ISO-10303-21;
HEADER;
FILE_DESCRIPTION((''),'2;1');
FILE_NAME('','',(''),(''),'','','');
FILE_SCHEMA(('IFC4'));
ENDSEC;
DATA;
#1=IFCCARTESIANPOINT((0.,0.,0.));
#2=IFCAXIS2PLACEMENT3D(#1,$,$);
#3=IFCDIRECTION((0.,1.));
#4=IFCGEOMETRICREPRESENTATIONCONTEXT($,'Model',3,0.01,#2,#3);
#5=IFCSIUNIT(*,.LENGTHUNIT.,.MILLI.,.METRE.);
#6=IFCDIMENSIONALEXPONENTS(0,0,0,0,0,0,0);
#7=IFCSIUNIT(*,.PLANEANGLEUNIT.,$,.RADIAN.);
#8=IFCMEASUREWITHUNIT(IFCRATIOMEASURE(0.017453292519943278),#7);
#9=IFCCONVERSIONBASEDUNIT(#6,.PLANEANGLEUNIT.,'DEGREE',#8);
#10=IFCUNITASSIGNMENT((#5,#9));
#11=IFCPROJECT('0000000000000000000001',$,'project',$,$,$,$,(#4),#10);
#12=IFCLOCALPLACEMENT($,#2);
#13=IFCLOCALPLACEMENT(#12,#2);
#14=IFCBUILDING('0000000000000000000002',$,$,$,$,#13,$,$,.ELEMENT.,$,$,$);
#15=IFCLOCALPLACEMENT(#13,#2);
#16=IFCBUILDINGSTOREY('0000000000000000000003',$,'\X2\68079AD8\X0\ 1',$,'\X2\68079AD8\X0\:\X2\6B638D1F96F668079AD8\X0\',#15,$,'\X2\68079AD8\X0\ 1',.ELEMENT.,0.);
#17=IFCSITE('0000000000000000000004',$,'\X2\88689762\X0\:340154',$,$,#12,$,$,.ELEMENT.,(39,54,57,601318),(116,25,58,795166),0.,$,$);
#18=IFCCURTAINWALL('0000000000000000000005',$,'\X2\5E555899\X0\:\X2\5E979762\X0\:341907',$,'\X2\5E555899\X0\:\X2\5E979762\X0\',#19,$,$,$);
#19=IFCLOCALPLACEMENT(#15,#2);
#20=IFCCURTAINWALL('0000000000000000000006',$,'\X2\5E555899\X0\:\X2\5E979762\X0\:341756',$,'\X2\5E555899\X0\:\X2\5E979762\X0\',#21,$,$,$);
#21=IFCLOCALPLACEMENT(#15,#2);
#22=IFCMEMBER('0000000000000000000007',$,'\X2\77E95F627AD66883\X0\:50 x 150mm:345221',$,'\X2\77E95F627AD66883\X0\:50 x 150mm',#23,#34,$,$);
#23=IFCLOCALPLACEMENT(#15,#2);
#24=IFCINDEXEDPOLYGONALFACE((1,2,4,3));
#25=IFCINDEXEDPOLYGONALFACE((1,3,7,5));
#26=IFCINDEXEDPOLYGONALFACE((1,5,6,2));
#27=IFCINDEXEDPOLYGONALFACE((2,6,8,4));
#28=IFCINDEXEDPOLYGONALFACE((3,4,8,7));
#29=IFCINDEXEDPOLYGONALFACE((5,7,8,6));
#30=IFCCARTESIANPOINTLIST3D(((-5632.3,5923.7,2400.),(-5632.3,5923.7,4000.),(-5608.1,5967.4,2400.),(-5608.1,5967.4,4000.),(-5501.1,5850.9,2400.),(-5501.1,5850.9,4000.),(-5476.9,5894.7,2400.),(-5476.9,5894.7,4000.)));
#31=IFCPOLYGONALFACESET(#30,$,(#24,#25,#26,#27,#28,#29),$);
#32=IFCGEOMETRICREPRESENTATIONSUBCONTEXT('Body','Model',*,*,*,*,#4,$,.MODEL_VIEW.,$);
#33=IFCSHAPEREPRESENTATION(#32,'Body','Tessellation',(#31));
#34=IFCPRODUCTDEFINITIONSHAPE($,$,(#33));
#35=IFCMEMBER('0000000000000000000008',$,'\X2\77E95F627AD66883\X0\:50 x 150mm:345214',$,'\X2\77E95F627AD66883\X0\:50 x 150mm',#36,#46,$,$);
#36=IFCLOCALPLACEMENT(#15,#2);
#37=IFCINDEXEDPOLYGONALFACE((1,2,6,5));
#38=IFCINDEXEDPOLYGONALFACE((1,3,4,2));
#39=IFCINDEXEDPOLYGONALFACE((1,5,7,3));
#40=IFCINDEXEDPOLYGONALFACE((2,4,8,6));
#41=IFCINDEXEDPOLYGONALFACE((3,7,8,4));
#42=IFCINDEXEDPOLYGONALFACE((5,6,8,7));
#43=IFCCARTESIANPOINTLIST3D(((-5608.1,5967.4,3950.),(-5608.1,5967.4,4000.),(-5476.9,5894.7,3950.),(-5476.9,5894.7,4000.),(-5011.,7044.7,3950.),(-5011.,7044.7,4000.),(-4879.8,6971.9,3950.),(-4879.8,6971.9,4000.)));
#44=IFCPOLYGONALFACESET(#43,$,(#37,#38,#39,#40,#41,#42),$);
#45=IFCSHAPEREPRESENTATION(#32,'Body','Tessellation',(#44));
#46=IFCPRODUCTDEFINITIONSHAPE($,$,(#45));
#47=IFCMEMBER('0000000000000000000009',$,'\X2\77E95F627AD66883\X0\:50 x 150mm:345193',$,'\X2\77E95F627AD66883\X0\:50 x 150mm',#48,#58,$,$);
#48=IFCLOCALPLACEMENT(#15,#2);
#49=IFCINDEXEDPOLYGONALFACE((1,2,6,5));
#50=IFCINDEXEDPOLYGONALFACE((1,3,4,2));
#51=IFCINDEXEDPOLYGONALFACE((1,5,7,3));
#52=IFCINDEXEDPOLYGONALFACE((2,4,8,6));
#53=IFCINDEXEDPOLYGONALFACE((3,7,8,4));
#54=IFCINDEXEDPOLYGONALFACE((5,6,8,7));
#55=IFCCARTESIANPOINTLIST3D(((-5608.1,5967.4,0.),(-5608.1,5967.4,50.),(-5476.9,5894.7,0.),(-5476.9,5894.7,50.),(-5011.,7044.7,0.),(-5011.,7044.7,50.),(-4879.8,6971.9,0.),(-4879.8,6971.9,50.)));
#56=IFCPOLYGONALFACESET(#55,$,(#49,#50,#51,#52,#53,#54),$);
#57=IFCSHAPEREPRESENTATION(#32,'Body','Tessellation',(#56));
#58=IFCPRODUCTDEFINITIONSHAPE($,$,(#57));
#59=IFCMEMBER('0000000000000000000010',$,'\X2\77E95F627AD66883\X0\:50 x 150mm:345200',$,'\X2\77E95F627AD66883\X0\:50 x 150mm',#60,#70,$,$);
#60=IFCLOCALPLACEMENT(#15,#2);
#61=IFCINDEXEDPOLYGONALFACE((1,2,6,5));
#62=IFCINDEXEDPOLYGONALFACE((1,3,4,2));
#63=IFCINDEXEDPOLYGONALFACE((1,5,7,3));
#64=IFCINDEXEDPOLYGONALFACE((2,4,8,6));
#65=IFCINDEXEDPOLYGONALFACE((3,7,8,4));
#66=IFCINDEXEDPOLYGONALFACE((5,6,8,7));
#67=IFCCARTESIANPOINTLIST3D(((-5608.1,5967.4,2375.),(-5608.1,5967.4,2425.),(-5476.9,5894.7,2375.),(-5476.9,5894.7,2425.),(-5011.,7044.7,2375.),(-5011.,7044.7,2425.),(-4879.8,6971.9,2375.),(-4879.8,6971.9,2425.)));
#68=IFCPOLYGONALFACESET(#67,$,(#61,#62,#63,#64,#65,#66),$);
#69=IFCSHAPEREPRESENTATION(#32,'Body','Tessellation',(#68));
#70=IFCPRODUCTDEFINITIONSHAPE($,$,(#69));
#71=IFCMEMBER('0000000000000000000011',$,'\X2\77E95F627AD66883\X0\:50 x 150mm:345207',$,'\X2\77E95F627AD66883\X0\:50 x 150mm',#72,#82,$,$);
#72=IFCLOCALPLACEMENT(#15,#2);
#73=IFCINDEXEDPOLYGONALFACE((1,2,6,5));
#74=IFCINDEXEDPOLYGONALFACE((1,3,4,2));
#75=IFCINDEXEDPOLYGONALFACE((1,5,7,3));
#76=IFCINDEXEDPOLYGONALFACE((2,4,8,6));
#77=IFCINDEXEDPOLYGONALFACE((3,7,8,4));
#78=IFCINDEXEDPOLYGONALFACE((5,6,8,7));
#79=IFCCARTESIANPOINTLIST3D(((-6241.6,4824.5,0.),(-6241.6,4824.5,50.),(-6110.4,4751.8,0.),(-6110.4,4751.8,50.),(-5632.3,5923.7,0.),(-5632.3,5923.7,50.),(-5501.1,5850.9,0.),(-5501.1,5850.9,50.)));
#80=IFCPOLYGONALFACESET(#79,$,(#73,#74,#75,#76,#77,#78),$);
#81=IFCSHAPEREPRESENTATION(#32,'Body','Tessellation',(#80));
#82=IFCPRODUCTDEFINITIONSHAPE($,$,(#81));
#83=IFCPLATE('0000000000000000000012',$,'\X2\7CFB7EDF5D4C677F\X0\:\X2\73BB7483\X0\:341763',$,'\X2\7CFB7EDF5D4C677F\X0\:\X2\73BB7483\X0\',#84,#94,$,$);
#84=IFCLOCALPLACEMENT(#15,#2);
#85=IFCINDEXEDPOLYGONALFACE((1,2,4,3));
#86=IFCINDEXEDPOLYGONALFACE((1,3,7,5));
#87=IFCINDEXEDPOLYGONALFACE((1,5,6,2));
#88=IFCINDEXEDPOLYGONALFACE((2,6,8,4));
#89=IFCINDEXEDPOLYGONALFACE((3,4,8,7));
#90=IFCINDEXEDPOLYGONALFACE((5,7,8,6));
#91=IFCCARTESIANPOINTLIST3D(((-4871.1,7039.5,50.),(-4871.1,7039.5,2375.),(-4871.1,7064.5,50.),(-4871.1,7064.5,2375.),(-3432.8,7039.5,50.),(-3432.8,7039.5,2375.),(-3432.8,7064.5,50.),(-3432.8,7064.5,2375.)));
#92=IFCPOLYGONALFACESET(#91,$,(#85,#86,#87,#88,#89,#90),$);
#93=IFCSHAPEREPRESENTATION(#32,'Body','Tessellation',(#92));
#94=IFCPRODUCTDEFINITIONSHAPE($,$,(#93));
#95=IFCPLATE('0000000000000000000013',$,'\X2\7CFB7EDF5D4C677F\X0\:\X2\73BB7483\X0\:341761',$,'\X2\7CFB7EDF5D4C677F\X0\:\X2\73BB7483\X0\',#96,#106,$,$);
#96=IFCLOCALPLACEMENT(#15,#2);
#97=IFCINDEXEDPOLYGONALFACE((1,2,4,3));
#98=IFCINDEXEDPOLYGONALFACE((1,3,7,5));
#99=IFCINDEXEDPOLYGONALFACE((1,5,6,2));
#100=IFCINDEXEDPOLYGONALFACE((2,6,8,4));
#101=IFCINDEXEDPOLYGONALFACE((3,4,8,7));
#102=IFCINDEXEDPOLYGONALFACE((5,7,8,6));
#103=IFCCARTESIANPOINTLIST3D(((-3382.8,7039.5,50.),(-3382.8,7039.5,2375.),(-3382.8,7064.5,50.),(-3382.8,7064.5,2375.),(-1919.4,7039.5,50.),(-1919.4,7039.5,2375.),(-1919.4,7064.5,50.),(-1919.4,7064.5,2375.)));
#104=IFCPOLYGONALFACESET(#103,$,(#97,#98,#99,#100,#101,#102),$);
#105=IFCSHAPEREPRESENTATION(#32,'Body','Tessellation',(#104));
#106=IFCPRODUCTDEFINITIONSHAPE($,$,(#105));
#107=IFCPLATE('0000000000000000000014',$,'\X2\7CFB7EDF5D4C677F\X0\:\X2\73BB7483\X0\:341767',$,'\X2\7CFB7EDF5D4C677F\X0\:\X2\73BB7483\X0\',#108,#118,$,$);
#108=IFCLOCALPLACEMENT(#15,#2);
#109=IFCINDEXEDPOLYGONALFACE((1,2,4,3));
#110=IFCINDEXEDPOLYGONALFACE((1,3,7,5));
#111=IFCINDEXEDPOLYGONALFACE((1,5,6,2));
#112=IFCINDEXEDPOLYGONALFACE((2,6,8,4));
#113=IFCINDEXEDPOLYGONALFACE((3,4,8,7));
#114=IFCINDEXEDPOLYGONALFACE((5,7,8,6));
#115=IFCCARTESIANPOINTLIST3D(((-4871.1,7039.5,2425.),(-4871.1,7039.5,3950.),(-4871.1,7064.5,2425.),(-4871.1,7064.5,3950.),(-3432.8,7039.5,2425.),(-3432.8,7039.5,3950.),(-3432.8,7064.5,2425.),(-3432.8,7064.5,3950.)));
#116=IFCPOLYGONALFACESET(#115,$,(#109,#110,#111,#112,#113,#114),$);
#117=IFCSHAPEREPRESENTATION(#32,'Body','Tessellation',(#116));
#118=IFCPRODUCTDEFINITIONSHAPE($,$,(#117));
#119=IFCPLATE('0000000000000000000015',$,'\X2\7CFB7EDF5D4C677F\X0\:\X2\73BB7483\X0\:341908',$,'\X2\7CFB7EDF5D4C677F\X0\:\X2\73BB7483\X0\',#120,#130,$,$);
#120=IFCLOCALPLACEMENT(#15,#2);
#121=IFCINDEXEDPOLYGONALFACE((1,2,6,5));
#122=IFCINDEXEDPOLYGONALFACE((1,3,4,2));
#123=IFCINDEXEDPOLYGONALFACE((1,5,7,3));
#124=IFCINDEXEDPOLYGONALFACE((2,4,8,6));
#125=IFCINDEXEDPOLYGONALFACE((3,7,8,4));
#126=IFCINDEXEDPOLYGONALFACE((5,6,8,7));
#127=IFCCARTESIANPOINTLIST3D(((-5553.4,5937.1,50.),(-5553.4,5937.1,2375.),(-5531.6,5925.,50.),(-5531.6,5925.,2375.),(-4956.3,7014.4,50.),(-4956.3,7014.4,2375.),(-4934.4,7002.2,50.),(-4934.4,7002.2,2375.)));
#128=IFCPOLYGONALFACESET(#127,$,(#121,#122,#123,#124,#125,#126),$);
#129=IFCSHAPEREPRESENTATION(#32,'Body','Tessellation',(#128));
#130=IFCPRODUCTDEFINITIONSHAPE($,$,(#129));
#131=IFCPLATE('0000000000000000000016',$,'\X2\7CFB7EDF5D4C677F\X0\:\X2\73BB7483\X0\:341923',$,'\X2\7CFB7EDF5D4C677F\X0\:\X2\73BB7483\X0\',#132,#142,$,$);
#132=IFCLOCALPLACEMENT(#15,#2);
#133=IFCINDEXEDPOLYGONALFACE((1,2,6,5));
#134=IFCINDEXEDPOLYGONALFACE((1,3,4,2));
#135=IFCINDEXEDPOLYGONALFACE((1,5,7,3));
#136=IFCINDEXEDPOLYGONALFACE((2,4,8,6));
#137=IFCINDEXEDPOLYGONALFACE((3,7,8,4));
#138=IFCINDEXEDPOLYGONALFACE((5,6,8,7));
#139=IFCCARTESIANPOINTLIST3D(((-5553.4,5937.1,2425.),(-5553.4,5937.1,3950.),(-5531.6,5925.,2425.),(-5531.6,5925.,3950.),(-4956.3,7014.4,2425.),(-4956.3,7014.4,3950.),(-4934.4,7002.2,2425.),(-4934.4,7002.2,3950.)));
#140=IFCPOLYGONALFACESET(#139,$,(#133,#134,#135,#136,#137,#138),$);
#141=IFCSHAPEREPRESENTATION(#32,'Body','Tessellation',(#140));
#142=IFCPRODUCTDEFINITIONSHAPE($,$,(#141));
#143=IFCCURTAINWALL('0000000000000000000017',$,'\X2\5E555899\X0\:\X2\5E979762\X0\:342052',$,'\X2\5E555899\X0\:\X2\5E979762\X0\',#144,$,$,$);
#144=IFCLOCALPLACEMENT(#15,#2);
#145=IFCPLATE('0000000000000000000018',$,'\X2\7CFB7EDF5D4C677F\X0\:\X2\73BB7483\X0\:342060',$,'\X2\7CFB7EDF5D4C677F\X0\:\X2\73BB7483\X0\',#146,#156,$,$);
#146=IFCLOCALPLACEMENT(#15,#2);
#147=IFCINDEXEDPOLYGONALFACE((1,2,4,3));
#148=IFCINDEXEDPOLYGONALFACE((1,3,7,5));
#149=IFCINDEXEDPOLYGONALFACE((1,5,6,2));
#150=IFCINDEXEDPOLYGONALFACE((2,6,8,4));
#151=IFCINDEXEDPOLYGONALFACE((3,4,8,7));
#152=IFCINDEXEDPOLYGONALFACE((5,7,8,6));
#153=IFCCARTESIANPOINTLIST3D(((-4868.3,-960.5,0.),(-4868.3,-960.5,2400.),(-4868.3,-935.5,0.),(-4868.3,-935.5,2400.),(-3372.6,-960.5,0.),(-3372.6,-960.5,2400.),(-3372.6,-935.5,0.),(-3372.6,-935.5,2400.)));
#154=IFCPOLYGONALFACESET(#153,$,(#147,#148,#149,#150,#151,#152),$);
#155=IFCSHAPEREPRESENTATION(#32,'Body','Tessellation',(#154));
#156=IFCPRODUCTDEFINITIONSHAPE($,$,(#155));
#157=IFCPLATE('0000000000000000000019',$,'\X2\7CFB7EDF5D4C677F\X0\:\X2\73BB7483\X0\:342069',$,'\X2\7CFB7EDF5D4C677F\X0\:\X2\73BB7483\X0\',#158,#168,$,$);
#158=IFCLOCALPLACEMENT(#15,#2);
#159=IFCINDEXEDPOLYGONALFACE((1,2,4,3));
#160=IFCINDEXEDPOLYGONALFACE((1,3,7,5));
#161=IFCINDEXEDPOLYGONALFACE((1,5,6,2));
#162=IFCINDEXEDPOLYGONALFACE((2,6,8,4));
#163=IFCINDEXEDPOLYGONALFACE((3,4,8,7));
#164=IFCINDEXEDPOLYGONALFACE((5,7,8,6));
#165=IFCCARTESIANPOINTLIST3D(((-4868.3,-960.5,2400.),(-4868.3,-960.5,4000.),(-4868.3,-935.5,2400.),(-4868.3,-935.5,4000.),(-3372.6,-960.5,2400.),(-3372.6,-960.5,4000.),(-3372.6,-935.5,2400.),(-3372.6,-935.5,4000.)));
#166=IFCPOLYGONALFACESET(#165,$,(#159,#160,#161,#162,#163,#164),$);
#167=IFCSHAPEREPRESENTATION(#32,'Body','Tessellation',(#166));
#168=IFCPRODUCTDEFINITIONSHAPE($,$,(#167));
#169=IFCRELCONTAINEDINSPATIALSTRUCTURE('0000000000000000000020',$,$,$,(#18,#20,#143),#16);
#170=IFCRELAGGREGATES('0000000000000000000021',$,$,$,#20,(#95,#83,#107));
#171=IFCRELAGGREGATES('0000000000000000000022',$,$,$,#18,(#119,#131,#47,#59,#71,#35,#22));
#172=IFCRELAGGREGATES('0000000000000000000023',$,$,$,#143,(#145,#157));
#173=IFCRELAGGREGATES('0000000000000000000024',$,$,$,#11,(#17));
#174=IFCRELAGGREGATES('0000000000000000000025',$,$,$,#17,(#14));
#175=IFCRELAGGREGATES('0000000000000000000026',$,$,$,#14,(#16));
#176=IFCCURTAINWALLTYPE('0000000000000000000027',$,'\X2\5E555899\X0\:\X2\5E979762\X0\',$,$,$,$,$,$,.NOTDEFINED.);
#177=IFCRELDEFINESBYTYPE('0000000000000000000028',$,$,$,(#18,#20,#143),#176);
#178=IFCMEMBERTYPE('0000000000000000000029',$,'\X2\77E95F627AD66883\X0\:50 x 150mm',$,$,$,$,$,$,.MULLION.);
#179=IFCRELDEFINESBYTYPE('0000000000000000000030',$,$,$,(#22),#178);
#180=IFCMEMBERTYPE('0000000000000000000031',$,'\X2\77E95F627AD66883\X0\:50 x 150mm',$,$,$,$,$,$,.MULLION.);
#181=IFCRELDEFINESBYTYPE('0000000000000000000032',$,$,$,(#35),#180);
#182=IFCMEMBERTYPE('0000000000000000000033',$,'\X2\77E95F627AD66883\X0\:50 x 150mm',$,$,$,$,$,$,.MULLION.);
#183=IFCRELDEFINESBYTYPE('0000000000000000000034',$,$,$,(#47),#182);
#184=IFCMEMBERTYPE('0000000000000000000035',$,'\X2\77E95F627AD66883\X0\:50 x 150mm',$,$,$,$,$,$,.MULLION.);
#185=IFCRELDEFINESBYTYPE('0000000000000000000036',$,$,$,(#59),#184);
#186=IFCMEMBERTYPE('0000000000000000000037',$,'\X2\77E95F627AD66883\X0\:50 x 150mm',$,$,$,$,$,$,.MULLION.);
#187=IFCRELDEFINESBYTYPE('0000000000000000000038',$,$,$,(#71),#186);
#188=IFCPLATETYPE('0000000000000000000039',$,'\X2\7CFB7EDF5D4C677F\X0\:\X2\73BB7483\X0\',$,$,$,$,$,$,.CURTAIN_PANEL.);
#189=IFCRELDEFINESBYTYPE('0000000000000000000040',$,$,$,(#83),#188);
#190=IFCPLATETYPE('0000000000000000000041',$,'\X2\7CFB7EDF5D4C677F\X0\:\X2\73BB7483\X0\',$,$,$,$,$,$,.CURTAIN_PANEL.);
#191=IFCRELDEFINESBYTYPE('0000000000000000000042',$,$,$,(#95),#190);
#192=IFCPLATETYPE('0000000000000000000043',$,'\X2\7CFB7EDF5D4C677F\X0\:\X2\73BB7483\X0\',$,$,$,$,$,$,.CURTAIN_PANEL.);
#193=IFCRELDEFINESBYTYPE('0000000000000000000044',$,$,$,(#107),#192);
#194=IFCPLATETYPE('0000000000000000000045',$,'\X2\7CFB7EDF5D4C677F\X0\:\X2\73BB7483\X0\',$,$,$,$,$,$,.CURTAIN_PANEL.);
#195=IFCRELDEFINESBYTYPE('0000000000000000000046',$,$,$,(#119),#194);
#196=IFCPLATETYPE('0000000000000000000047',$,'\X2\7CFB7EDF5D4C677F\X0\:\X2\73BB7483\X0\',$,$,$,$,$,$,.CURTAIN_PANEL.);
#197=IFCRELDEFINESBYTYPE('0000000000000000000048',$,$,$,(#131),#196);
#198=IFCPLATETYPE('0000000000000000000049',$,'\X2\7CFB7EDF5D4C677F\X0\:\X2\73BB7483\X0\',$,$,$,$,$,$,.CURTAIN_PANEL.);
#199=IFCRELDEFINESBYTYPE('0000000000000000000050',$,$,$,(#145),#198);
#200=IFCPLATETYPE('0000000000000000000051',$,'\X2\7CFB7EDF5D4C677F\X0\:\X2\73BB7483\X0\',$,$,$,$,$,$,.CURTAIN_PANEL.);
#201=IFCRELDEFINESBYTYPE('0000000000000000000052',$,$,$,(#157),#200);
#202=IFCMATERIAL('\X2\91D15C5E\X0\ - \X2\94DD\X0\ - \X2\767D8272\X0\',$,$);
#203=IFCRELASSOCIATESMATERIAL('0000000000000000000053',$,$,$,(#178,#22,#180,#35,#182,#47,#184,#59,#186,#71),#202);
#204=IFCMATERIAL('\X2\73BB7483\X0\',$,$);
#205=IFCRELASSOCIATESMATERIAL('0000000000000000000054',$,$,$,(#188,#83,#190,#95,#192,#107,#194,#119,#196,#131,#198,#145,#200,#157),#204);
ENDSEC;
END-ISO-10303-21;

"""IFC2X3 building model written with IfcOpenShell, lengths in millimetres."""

from ifc_helpers import new_model, entity, si_unit, converted_unit, direction, frame, frame_2d, origin, origin_2d_with_axis, place, context, subcontext, project, spatial, rectangle, extrude, source, transform, mapped, material, type_object, type_shapes, element, aggregate, save


model = new_model("IFC2X3")

# Units and contexts
model_context = context("Model", 3, precision=0.01, world=origin(), true_north=direction((0.0, 1.0)))
body_context = subcontext(model_context, "Body", "Model", "MODEL_VIEW")
ifc_project = project(units=[si_unit("LENGTHUNIT", "METRE", prefix="MILLI"), converted_unit("PLANEANGLEUNIT", "DEGREE", entity("IfcRatioMeasure", 0.017453292519943278), si_unit("PLANEANGLEUNIT", "RADIAN"), dimensions=[0, 0, 0, 0, 0, 0, 0])], contexts=[model_context])

# Site, building, storey
site_placement = place(None, origin())
site = spatial("IfcSite", under=ifc_project, at=site_placement, Name="表面:340154", CompositionType="ELEMENT", RefLatitude=(39, 54, 57, 601318), RefLongitude=(116, 25, 58, 795166), RefElevation=0.0)
building_placement = place(site_placement, origin())
building = spatial("IfcBuilding", under=site, at=building_placement, CompositionType="ELEMENT")
storey_placement = place(building_placement, origin())
storey = spatial("IfcBuildingStorey", under=building, at=storey_placement, Name="标高 1", ObjectType="标高:正负零标高", LongName="标高 1", CompositionType="ELEMENT", Elevation=0.0)

# Curtain wall
curtain_wall_type = type_object("IfcCurtainWallType", Name="幕墙:店面", PredefinedType="NOTDEFINED")
curtain_wall_1_placement = place(storey_placement, origin())
curtain_wall_1 = element("IfcCurtainWall", 1, at=curtain_wall_1_placement, inside=storey, type_object=curtain_wall_type, Name="幕墙:店面:341907", ObjectType="幕墙:店面")
ifc_material_1 = material(Name="金属 - 铝 - 白色")

# Curtain wall
curtain_wall_2_placement = place(storey_placement, origin())
curtain_wall_2 = element("IfcCurtainWall", 2, at=curtain_wall_2_placement, inside=storey, type_object=curtain_wall_type, Name="幕墙:店面:341756", ObjectType="幕墙:店面")

# Members
member_type_1 = type_object("IfcMemberType", Name="矩形竖梃:50 x 150mm", PredefinedType="MULLION", material=ifc_material_1)
shared_shape_1 = source(origin(), body_context, "Body", "SweptSolid", [
    extrude(rectangle(XDim=150.0, YDim=50.0, at=origin_2d_with_axis()), frame((0.0, 0.0, -1600.0), z_axis=(0.0, 0.0, 1.0), x_axis=(0.0, -1.0, 0.0)), (0.0, 0.0, 1.0), 1600.0),
])
type_shapes(member_type_1, [shared_shape_1])
member_1_placement = place(curtain_wall_1_placement, frame((-5554.6, 5909.2, 2400.0), z_axis=(0.0, 0.0, -1.0), x_axis=(-0.48481, -0.87462, 0.0)))
member_1 = element("IfcMember", 3, at=member_1_placement, type_object=member_type_1, material=ifc_material_1, Name="矩形竖梃:50 x 150mm:345221", ObjectType="矩形竖梃:50 x 150mm", context=body_context, shape_type="MappedRepresentation", body=[
    mapped(shared_shape_1, transform((0.0, 0.0, 0.0), scale=1.0)),
])
member_type_2 = type_object("IfcMemberType", Name="矩形竖梃:50 x 150mm", PredefinedType="MULLION", material=ifc_material_1)
shared_shape_2 = source(origin(), body_context, "Body", "SweptSolid", [
    extrude(rectangle(XDim=150.0, YDim=50.0, at=origin_2d_with_axis()), frame((-25.0, 0.0, -1231.7), z_axis=(0.0, 0.0, 1.0), x_axis=(0.0, -1.0, 0.0)), (0.0, 0.0, 1.0), 1231.7),
])
type_shapes(member_type_2, [shared_shape_2])
member_2_placement = place(curtain_wall_1_placement, frame((-5542.5, 5931.0, 4000.0), z_axis=(-0.48481, -0.87462, 0.0), x_axis=(0.0, 0.0, 1.0)))
member_2 = element("IfcMember", 4, at=member_2_placement, type_object=member_type_2, material=ifc_material_1, Name="矩形竖梃:50 x 150mm:345214", ObjectType="矩形竖梃:50 x 150mm", context=body_context, shape_type="MappedRepresentation", body=[
    mapped(shared_shape_2, transform((0.0, 0.0, 0.0), scale=1.0)),
])
member_type_3 = type_object("IfcMemberType", Name="矩形竖梃:50 x 150mm", PredefinedType="MULLION", material=ifc_material_1)
shared_shape_3 = source(origin(), body_context, "Body", "SweptSolid", [
    extrude(rectangle(XDim=150.0, YDim=50.0, at=origin_2d_with_axis()), frame((-25.0, 0.0, -1231.7), z_axis=(0.0, 0.0, 1.0), x_axis=(0.0, -1.0, 0.0)), (0.0, 0.0, 1.0), 1231.7),
])
type_shapes(member_type_3, [shared_shape_3])
member_3_placement = place(curtain_wall_1_placement, frame((-4945.4, 7008.3, 0.0), z_axis=(0.48481, 0.87462, 0.0), x_axis=(0.0, 0.0, -1.0)))
member_3 = element("IfcMember", 5, at=member_3_placement, type_object=member_type_3, material=ifc_material_1, Name="矩形竖梃:50 x 150mm:345193", ObjectType="矩形竖梃:50 x 150mm", context=body_context, shape_type="MappedRepresentation", body=[
    mapped(shared_shape_3, transform((0.0, 0.0, 0.0), scale=1.0)),
])
member_type_4 = type_object("IfcMemberType", Name="矩形竖梃:50 x 150mm", PredefinedType="MULLION", material=ifc_material_1)
shared_shape_4 = source(origin(), body_context, "Body", "SweptSolid", [
    extrude(rectangle(XDim=150.0, YDim=50.0, at=origin_2d_with_axis()), frame((0.0, 0.0, -1231.7), z_axis=(0.0, 0.0, 1.0), x_axis=(0.0, -1.0, 0.0)), (0.0, 0.0, 1.0), 1231.7),
])
type_shapes(member_type_4, [shared_shape_4])
member_4_placement = place(curtain_wall_1_placement, frame((-5542.5, 5931.0, 2400.0), z_axis=(-0.48481, -0.87462, 0.0), x_axis=(0.0, 0.0, 1.0)))
member_4 = element("IfcMember", 6, at=member_4_placement, type_object=member_type_4, material=ifc_material_1, Name="矩形竖梃:50 x 150mm:345200", ObjectType="矩形竖梃:50 x 150mm", context=body_context, shape_type="MappedRepresentation", body=[
    mapped(shared_shape_4, transform((0.0, 0.0, 0.0), scale=1.0)),
])
member_type_5 = type_object("IfcMemberType", Name="矩形竖梃:50 x 150mm", PredefinedType="MULLION", material=ifc_material_1)
shared_shape_5 = source(origin(), body_context, "Body", "SweptSolid", [
    extrude(rectangle(XDim=150.0, YDim=50.0, at=origin_2d_with_axis()), frame((-25.0, 0.0, -1256.7), z_axis=(0.0, 0.0, 1.0), x_axis=(0.0, -1.0, 0.0)), (0.0, 0.0, 1.0), 1256.7),
])
type_shapes(member_type_5, [shared_shape_5])
member_5_placement = place(curtain_wall_1_placement, frame((-5566.7, 5887.3, 0.0), z_axis=(0.48481, 0.87462, 0.0), x_axis=(0.0, 0.0, -1.0)))
member_5 = element("IfcMember", 7, at=member_5_placement, type_object=member_type_5, material=ifc_material_1, Name="矩形竖梃:50 x 150mm:345207", ObjectType="矩形竖梃:50 x 150mm", context=body_context, shape_type="MappedRepresentation", body=[
    mapped(shared_shape_5, transform((0.0, 0.0, 0.0), scale=1.0)),
])

# Plates
ifc_material_2 = material(Name="玻璃")
plate_type_1 = type_object("IfcPlateType", Name="系统嵌板:玻璃", PredefinedType="CURTAIN_PANEL", material=ifc_material_2)
shared_shape_6 = source(origin(), body_context, "Body", "SweptSolid", [
    extrude(rectangle(XDim=25.0, YDim=1438.3, at=origin_2d_with_axis()), frame((0.0, 0.0, 0.0), z_axis=(0.0, 0.0, 1.0), x_axis=(0.0, 1.0, 0.0)), (0.0, 0.0, 1.0), 2325.0),
])
type_shapes(plate_type_1, [shared_shape_6])
plate_1_placement = place(curtain_wall_2_placement, frame((-4151.9, 7052.0, 50.0), z_axis=(0.0, 0.0, 1.0), x_axis=(-1.0, 0.0, 0.0)))
plate_1 = element("IfcPlate", 8, at=plate_1_placement, type_object=plate_type_1, material=ifc_material_2, Name="系统嵌板:玻璃:341763", ObjectType="系统嵌板:玻璃", context=body_context, shape_type="MappedRepresentation", body=[
    mapped(shared_shape_6, transform((0.0, 0.0, 0.0), scale=1.0)),
])
plate_type_2 = type_object("IfcPlateType", Name="系统嵌板:玻璃", PredefinedType="CURTAIN_PANEL", material=ifc_material_2)
shared_shape_7 = source(origin(), body_context, "Body", "SweptSolid", [
    extrude(rectangle(XDim=25.0, YDim=1463.3, at=origin_2d_with_axis()), frame((0.0, 0.0, 0.0), z_axis=(0.0, 0.0, 1.0), x_axis=(0.0, 1.0, 0.0)), (0.0, 0.0, 1.0), 2325.0),
])
type_shapes(plate_type_2, [shared_shape_7])
plate_2_placement = place(curtain_wall_2_placement, frame((-2651.1, 7052.0, 50.0), z_axis=(0.0, 0.0, 1.0), x_axis=(-1.0, 0.0, 0.0)))
plate_2 = element("IfcPlate", 9, at=plate_2_placement, type_object=plate_type_2, material=ifc_material_2, Name="系统嵌板:玻璃:341761", ObjectType="系统嵌板:玻璃", context=body_context, shape_type="MappedRepresentation", body=[
    mapped(shared_shape_7, transform((0.0, 0.0, 0.0), scale=1.0)),
])
plate_type_3 = type_object("IfcPlateType", Name="系统嵌板:玻璃", PredefinedType="CURTAIN_PANEL", material=ifc_material_2)
shared_shape_8 = source(origin(), body_context, "Body", "SweptSolid", [
    extrude(rectangle(XDim=25.0, YDim=1438.3, at=origin_2d_with_axis()), frame((0.0, 0.0, 0.0), z_axis=(0.0, 0.0, 1.0), x_axis=(0.0, 1.0, 0.0)), (0.0, 0.0, 1.0), 1525.0),
])
type_shapes(plate_type_3, [shared_shape_8])
plate_3_placement = place(curtain_wall_2_placement, frame((-4151.9, 7052.0, 2425.0), z_axis=(0.0, 0.0, 1.0), x_axis=(-1.0, 0.0, 0.0)))
plate_3 = element("IfcPlate", 10, at=plate_3_placement, type_object=plate_type_3, material=ifc_material_2, Name="系统嵌板:玻璃:341767", ObjectType="系统嵌板:玻璃", context=body_context, shape_type="MappedRepresentation", body=[
    mapped(shared_shape_8, transform((0.0, 0.0, 0.0), scale=1.0)),
])
aggregate(curtain_wall_2, [plate_2, plate_1, plate_3])
plate_type_4 = type_object("IfcPlateType", Name="系统嵌板:玻璃", PredefinedType="CURTAIN_PANEL", material=ifc_material_2)
shared_shape_9 = source(origin(), body_context, "Body", "SweptSolid", [
    extrude(rectangle(XDim=25.0, YDim=1231.7, at=frame_2d((0.0, 0.0), x_axis=(1.0, 0.0))), frame((0.0, 0.0, 0.0), z_axis=(0.0, 0.0, 1.0), x_axis=(0.0, 1.0, 0.0)), (0.0, 0.0, 1.0), 2325.0),
])
type_shapes(plate_type_4, [shared_shape_9])
plate_4_placement = place(curtain_wall_1_placement, frame((-5243.9, 6469.7, 50.0), z_axis=(0.0, 0.0, 1.0), x_axis=(-0.48481, -0.87462, 0.0)))
plate_4 = element("IfcPlate", 11, at=plate_4_placement, type_object=plate_type_4, material=ifc_material_2, Name="系统嵌板:玻璃:341908", ObjectType="系统嵌板:玻璃", context=body_context, shape_type="MappedRepresentation", body=[
    mapped(shared_shape_9, transform((0.0, 0.0, 0.0), scale=1.0)),
])
plate_type_5 = type_object("IfcPlateType", Name="系统嵌板:玻璃", PredefinedType="CURTAIN_PANEL", material=ifc_material_2)
shared_shape_10 = source(origin(), body_context, "Body", "SweptSolid", [
    extrude(rectangle(XDim=25.0, YDim=1231.7, at=frame_2d((0.0, 0.0), x_axis=(1.0, 0.0))), frame((0.0, 0.0, 0.0), z_axis=(0.0, 0.0, 1.0), x_axis=(0.0, 1.0, 0.0)), (0.0, 0.0, 1.0), 1525.0),
])
type_shapes(plate_type_5, [shared_shape_10])
plate_5_placement = place(curtain_wall_1_placement, frame((-5243.9, 6469.7, 2425.0), z_axis=(0.0, 0.0, 1.0), x_axis=(-0.48481, -0.87462, 0.0)))
plate_5 = element("IfcPlate", 12, at=plate_5_placement, type_object=plate_type_5, material=ifc_material_2, Name="系统嵌板:玻璃:341923", ObjectType="系统嵌板:玻璃", context=body_context, shape_type="MappedRepresentation", body=[
    mapped(shared_shape_10, transform((0.0, 0.0, 0.0), scale=1.0)),
])
aggregate(curtain_wall_1, [plate_4, plate_5, member_3, member_4, member_5, member_2, member_1])

# Curtain wall, plates
curtain_wall_3_placement = place(storey_placement, origin())
curtain_wall_3 = element("IfcCurtainWall", 13, at=curtain_wall_3_placement, inside=storey, type_object=curtain_wall_type, Name="幕墙:店面:342052", ObjectType="幕墙:店面")
plate_type_6 = type_object("IfcPlateType", Name="系统嵌板:玻璃", PredefinedType="CURTAIN_PANEL", material=ifc_material_2)
shared_shape_11 = source(origin(), body_context, "Body", "SweptSolid", [
    extrude(rectangle(XDim=25.0, YDim=1495.8, at=origin_2d_with_axis()), frame((0.0, 0.0, 0.0), z_axis=(0.0, 0.0, 1.0), x_axis=(0.0, 1.0, 0.0)), (0.0, 0.0, 1.0), 2400.0),
])
type_shapes(plate_type_6, [shared_shape_11])
plate_6_placement = place(curtain_wall_3_placement, frame((-4120.5, -948.0, 0.0)))
plate_6 = element("IfcPlate", 14, at=plate_6_placement, type_object=plate_type_6, material=ifc_material_2, Name="系统嵌板:玻璃:342060", ObjectType="系统嵌板:玻璃", context=body_context, shape_type="MappedRepresentation", body=[
    mapped(shared_shape_11, transform((0.0, 0.0, 0.0), scale=1.0)),
])
plate_type_7 = type_object("IfcPlateType", Name="系统嵌板:玻璃", PredefinedType="CURTAIN_PANEL", material=ifc_material_2)
shared_shape_12 = source(origin(), body_context, "Body", "SweptSolid", [
    extrude(rectangle(XDim=25.0, YDim=1495.8, at=origin_2d_with_axis()), frame((0.0, 0.0, 0.0), z_axis=(0.0, 0.0, 1.0), x_axis=(0.0, 1.0, 0.0)), (0.0, 0.0, 1.0), 1600.0),
])
type_shapes(plate_type_7, [shared_shape_12])
plate_7_placement = place(curtain_wall_3_placement, frame((-4120.5, -948.0, 2400.0)))
plate_7 = element("IfcPlate", 15, at=plate_7_placement, type_object=plate_type_7, material=ifc_material_2, Name="系统嵌板:玻璃:342069", ObjectType="系统嵌板:玻璃", context=body_context, shape_type="MappedRepresentation", body=[
    mapped(shared_shape_12, transform((0.0, 0.0, 0.0), scale=1.0)),
])
aggregate(curtain_wall_3, [plate_6, plate_7])

save(model, "model.ifc")
